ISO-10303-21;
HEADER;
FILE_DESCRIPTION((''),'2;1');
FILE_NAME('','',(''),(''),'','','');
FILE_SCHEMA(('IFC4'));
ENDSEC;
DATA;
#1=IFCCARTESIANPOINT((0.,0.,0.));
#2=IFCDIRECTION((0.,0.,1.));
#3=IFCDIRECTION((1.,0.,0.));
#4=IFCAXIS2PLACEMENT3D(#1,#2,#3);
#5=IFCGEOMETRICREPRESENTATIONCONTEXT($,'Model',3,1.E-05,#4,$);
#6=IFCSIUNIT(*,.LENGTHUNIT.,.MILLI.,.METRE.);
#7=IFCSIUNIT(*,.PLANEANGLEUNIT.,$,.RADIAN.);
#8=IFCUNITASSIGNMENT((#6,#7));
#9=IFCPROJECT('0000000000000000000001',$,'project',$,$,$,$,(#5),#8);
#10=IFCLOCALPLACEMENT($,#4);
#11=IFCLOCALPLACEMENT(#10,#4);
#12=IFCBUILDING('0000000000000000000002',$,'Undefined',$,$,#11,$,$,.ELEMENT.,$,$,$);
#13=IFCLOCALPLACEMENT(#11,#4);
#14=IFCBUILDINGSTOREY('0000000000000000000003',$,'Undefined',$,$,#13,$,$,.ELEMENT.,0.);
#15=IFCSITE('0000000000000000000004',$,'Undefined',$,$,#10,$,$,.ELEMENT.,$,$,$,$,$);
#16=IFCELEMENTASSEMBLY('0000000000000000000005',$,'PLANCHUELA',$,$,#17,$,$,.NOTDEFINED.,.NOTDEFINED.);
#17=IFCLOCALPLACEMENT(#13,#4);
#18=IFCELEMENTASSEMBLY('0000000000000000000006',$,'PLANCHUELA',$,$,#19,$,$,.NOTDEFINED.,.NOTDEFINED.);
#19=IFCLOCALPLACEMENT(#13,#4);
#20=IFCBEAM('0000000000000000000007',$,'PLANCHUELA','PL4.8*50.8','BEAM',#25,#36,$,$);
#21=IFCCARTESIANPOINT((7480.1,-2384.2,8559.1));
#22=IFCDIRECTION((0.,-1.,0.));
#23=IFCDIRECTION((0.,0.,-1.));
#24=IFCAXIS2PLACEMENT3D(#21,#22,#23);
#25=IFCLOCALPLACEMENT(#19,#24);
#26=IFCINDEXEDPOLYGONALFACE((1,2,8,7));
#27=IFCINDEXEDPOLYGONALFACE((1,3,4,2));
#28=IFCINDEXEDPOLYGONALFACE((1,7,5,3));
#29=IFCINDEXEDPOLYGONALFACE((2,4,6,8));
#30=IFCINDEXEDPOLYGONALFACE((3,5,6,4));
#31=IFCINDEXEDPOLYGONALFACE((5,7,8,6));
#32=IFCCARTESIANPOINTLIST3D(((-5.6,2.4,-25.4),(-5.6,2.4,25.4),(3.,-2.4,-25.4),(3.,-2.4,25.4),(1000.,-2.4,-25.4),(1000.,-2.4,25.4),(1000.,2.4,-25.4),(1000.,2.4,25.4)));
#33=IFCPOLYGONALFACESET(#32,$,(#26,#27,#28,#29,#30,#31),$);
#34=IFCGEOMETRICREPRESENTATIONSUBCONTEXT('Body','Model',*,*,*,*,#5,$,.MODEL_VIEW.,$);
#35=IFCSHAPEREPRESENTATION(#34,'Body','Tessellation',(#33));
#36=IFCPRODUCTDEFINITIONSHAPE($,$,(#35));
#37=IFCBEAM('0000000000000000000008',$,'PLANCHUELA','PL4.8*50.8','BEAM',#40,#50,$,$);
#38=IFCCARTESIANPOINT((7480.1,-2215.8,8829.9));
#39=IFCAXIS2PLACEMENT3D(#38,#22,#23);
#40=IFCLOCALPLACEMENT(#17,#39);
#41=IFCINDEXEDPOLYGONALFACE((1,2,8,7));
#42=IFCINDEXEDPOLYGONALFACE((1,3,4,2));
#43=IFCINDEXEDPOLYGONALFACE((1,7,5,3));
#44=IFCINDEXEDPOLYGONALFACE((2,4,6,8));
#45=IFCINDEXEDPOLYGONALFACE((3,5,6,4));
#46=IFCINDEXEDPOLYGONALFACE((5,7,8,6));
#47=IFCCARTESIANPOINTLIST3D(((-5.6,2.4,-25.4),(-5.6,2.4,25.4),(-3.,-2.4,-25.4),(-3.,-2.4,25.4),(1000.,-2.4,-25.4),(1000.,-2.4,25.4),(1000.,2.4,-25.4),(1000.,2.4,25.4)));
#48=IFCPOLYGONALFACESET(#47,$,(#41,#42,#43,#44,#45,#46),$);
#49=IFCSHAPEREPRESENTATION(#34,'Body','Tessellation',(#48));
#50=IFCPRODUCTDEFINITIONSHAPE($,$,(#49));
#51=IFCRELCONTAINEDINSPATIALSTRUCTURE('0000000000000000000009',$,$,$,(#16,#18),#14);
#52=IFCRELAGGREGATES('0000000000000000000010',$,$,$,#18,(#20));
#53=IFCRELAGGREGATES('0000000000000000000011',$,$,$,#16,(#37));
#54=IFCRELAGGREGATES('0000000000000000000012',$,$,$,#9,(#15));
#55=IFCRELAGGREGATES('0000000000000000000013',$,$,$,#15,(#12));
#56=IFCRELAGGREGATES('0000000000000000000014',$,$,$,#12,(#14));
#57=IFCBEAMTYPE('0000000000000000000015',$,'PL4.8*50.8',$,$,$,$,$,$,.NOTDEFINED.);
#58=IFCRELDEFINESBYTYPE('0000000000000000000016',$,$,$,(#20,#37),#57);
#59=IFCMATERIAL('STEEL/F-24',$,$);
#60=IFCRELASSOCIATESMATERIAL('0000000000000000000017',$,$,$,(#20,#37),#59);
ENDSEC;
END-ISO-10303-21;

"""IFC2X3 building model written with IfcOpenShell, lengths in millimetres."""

from ifc_helpers import new_model, si_unit, frame, origin_with_axes, origin_2d_with_axis, place, context, subcontext, project, spatial, rectangle, extrude, clip, halfspace, material, type_object, element, aggregate, save


model = new_model("IFC2X3")

# Units and contexts
model_context = context("Model", 3, precision=1e-05, world=origin_with_axes())
body_context = subcontext(model_context, "Body", "Model", "MODEL_VIEW")
ifc_project = project(units=[si_unit("LENGTHUNIT", "METRE", prefix="MILLI"), si_unit("PLANEANGLEUNIT", "RADIAN")], contexts=[model_context])

# Site, building, storey
site_placement = place(None, origin_with_axes())
site = spatial("IfcSite", under=ifc_project, at=site_placement, Name="Undefined", CompositionType="ELEMENT")
building_placement = place(site_placement, origin_with_axes())
building = spatial("IfcBuilding", under=site, at=building_placement, Name="Undefined", CompositionType="ELEMENT")
storey_placement = place(building_placement, origin_with_axes())
storey = spatial("IfcBuildingStorey", under=building, at=storey_placement, Name="Undefined", CompositionType="ELEMENT", Elevation=0.0)

# Element assembly
beam_type_1 = type_object("IfcBeamType", Name="PL4.8*50.8", PredefinedType="NOTDEFINED")
assembly_1_placement = place(storey_placement, origin_with_axes())
assembly_1 = element("IfcElementAssembly", 1, at=assembly_1_placement, inside=storey, Name="PLANCHUELA", AssemblyPlace="NOTDEFINED", PredefinedType="NOTDEFINED")
ifc_material_1 = material(Name="STEEL/F-24")

# Element assembly, beam
assembly_2_placement = place(storey_placement, origin_with_axes())
assembly_2 = element("IfcElementAssembly", 2, at=assembly_2_placement, inside=storey, Name="PLANCHUELA", AssemblyPlace="NOTDEFINED", PredefinedType="NOTDEFINED")
beam_1_placement = place(assembly_2_placement, frame((7480.1, -2384.2, 8559.1), z_axis=(0.0, -1.0, 0.0), x_axis=(0.0, 0.0, -1.0)))
beam_1 = element("IfcBeam", 3, at=beam_1_placement, type_object=beam_type_1, material=ifc_material_1, Name="PLANCHUELA", Description="PL4.8*50.8", ObjectType="BEAM", context=body_context, shape_type="Clipping", body=[
    clip(extrude(rectangle(XDim=4.8, YDim=50.8, at=origin_2d_with_axis()), frame((1000.0, 0.0, 0.0), z_axis=(-1.0, 0.0, 0.0), x_axis=(0.0, -1.0, 0.0)), (0.0, 0.0, 1.0), 1005.7), halfspace(frame((-5.6, 2.4, 0.0), z_axis=(-0.487408, -0.873174, 0.0), x_axis=(0.0, 0.0, 1.0)), False)),
])
aggregate(assembly_2, [beam_1])

# Beam
beam_2_placement = place(assembly_1_placement, frame((7480.1, -2215.8, 8829.9), z_axis=(0.0, -1.0, 0.0), x_axis=(0.0, 0.0, -1.0)))
beam_2 = element("IfcBeam", 4, at=beam_2_placement, type_object=beam_type_1, material=ifc_material_1, Name="PLANCHUELA", Description="PL4.8*50.8", ObjectType="BEAM", context=body_context, shape_type="Clipping", body=[
    clip(extrude(rectangle(XDim=4.8, YDim=50.8, at=origin_2d_with_axis()), frame((1000.0, 0.0, 0.0), z_axis=(-1.0, 0.0, 0.0), x_axis=(0.0, -1.0, 0.0)), (0.0, 0.0, 1.0), 1005.6), halfspace(frame((-3.0, -2.4, 0.0), z_axis=(-0.873181, -0.487397, 0.0), x_axis=(0.0, 0.0, -1.0)), False)),
])

aggregate(assembly_1, [beam_2])

save(model, "model.ifc")
